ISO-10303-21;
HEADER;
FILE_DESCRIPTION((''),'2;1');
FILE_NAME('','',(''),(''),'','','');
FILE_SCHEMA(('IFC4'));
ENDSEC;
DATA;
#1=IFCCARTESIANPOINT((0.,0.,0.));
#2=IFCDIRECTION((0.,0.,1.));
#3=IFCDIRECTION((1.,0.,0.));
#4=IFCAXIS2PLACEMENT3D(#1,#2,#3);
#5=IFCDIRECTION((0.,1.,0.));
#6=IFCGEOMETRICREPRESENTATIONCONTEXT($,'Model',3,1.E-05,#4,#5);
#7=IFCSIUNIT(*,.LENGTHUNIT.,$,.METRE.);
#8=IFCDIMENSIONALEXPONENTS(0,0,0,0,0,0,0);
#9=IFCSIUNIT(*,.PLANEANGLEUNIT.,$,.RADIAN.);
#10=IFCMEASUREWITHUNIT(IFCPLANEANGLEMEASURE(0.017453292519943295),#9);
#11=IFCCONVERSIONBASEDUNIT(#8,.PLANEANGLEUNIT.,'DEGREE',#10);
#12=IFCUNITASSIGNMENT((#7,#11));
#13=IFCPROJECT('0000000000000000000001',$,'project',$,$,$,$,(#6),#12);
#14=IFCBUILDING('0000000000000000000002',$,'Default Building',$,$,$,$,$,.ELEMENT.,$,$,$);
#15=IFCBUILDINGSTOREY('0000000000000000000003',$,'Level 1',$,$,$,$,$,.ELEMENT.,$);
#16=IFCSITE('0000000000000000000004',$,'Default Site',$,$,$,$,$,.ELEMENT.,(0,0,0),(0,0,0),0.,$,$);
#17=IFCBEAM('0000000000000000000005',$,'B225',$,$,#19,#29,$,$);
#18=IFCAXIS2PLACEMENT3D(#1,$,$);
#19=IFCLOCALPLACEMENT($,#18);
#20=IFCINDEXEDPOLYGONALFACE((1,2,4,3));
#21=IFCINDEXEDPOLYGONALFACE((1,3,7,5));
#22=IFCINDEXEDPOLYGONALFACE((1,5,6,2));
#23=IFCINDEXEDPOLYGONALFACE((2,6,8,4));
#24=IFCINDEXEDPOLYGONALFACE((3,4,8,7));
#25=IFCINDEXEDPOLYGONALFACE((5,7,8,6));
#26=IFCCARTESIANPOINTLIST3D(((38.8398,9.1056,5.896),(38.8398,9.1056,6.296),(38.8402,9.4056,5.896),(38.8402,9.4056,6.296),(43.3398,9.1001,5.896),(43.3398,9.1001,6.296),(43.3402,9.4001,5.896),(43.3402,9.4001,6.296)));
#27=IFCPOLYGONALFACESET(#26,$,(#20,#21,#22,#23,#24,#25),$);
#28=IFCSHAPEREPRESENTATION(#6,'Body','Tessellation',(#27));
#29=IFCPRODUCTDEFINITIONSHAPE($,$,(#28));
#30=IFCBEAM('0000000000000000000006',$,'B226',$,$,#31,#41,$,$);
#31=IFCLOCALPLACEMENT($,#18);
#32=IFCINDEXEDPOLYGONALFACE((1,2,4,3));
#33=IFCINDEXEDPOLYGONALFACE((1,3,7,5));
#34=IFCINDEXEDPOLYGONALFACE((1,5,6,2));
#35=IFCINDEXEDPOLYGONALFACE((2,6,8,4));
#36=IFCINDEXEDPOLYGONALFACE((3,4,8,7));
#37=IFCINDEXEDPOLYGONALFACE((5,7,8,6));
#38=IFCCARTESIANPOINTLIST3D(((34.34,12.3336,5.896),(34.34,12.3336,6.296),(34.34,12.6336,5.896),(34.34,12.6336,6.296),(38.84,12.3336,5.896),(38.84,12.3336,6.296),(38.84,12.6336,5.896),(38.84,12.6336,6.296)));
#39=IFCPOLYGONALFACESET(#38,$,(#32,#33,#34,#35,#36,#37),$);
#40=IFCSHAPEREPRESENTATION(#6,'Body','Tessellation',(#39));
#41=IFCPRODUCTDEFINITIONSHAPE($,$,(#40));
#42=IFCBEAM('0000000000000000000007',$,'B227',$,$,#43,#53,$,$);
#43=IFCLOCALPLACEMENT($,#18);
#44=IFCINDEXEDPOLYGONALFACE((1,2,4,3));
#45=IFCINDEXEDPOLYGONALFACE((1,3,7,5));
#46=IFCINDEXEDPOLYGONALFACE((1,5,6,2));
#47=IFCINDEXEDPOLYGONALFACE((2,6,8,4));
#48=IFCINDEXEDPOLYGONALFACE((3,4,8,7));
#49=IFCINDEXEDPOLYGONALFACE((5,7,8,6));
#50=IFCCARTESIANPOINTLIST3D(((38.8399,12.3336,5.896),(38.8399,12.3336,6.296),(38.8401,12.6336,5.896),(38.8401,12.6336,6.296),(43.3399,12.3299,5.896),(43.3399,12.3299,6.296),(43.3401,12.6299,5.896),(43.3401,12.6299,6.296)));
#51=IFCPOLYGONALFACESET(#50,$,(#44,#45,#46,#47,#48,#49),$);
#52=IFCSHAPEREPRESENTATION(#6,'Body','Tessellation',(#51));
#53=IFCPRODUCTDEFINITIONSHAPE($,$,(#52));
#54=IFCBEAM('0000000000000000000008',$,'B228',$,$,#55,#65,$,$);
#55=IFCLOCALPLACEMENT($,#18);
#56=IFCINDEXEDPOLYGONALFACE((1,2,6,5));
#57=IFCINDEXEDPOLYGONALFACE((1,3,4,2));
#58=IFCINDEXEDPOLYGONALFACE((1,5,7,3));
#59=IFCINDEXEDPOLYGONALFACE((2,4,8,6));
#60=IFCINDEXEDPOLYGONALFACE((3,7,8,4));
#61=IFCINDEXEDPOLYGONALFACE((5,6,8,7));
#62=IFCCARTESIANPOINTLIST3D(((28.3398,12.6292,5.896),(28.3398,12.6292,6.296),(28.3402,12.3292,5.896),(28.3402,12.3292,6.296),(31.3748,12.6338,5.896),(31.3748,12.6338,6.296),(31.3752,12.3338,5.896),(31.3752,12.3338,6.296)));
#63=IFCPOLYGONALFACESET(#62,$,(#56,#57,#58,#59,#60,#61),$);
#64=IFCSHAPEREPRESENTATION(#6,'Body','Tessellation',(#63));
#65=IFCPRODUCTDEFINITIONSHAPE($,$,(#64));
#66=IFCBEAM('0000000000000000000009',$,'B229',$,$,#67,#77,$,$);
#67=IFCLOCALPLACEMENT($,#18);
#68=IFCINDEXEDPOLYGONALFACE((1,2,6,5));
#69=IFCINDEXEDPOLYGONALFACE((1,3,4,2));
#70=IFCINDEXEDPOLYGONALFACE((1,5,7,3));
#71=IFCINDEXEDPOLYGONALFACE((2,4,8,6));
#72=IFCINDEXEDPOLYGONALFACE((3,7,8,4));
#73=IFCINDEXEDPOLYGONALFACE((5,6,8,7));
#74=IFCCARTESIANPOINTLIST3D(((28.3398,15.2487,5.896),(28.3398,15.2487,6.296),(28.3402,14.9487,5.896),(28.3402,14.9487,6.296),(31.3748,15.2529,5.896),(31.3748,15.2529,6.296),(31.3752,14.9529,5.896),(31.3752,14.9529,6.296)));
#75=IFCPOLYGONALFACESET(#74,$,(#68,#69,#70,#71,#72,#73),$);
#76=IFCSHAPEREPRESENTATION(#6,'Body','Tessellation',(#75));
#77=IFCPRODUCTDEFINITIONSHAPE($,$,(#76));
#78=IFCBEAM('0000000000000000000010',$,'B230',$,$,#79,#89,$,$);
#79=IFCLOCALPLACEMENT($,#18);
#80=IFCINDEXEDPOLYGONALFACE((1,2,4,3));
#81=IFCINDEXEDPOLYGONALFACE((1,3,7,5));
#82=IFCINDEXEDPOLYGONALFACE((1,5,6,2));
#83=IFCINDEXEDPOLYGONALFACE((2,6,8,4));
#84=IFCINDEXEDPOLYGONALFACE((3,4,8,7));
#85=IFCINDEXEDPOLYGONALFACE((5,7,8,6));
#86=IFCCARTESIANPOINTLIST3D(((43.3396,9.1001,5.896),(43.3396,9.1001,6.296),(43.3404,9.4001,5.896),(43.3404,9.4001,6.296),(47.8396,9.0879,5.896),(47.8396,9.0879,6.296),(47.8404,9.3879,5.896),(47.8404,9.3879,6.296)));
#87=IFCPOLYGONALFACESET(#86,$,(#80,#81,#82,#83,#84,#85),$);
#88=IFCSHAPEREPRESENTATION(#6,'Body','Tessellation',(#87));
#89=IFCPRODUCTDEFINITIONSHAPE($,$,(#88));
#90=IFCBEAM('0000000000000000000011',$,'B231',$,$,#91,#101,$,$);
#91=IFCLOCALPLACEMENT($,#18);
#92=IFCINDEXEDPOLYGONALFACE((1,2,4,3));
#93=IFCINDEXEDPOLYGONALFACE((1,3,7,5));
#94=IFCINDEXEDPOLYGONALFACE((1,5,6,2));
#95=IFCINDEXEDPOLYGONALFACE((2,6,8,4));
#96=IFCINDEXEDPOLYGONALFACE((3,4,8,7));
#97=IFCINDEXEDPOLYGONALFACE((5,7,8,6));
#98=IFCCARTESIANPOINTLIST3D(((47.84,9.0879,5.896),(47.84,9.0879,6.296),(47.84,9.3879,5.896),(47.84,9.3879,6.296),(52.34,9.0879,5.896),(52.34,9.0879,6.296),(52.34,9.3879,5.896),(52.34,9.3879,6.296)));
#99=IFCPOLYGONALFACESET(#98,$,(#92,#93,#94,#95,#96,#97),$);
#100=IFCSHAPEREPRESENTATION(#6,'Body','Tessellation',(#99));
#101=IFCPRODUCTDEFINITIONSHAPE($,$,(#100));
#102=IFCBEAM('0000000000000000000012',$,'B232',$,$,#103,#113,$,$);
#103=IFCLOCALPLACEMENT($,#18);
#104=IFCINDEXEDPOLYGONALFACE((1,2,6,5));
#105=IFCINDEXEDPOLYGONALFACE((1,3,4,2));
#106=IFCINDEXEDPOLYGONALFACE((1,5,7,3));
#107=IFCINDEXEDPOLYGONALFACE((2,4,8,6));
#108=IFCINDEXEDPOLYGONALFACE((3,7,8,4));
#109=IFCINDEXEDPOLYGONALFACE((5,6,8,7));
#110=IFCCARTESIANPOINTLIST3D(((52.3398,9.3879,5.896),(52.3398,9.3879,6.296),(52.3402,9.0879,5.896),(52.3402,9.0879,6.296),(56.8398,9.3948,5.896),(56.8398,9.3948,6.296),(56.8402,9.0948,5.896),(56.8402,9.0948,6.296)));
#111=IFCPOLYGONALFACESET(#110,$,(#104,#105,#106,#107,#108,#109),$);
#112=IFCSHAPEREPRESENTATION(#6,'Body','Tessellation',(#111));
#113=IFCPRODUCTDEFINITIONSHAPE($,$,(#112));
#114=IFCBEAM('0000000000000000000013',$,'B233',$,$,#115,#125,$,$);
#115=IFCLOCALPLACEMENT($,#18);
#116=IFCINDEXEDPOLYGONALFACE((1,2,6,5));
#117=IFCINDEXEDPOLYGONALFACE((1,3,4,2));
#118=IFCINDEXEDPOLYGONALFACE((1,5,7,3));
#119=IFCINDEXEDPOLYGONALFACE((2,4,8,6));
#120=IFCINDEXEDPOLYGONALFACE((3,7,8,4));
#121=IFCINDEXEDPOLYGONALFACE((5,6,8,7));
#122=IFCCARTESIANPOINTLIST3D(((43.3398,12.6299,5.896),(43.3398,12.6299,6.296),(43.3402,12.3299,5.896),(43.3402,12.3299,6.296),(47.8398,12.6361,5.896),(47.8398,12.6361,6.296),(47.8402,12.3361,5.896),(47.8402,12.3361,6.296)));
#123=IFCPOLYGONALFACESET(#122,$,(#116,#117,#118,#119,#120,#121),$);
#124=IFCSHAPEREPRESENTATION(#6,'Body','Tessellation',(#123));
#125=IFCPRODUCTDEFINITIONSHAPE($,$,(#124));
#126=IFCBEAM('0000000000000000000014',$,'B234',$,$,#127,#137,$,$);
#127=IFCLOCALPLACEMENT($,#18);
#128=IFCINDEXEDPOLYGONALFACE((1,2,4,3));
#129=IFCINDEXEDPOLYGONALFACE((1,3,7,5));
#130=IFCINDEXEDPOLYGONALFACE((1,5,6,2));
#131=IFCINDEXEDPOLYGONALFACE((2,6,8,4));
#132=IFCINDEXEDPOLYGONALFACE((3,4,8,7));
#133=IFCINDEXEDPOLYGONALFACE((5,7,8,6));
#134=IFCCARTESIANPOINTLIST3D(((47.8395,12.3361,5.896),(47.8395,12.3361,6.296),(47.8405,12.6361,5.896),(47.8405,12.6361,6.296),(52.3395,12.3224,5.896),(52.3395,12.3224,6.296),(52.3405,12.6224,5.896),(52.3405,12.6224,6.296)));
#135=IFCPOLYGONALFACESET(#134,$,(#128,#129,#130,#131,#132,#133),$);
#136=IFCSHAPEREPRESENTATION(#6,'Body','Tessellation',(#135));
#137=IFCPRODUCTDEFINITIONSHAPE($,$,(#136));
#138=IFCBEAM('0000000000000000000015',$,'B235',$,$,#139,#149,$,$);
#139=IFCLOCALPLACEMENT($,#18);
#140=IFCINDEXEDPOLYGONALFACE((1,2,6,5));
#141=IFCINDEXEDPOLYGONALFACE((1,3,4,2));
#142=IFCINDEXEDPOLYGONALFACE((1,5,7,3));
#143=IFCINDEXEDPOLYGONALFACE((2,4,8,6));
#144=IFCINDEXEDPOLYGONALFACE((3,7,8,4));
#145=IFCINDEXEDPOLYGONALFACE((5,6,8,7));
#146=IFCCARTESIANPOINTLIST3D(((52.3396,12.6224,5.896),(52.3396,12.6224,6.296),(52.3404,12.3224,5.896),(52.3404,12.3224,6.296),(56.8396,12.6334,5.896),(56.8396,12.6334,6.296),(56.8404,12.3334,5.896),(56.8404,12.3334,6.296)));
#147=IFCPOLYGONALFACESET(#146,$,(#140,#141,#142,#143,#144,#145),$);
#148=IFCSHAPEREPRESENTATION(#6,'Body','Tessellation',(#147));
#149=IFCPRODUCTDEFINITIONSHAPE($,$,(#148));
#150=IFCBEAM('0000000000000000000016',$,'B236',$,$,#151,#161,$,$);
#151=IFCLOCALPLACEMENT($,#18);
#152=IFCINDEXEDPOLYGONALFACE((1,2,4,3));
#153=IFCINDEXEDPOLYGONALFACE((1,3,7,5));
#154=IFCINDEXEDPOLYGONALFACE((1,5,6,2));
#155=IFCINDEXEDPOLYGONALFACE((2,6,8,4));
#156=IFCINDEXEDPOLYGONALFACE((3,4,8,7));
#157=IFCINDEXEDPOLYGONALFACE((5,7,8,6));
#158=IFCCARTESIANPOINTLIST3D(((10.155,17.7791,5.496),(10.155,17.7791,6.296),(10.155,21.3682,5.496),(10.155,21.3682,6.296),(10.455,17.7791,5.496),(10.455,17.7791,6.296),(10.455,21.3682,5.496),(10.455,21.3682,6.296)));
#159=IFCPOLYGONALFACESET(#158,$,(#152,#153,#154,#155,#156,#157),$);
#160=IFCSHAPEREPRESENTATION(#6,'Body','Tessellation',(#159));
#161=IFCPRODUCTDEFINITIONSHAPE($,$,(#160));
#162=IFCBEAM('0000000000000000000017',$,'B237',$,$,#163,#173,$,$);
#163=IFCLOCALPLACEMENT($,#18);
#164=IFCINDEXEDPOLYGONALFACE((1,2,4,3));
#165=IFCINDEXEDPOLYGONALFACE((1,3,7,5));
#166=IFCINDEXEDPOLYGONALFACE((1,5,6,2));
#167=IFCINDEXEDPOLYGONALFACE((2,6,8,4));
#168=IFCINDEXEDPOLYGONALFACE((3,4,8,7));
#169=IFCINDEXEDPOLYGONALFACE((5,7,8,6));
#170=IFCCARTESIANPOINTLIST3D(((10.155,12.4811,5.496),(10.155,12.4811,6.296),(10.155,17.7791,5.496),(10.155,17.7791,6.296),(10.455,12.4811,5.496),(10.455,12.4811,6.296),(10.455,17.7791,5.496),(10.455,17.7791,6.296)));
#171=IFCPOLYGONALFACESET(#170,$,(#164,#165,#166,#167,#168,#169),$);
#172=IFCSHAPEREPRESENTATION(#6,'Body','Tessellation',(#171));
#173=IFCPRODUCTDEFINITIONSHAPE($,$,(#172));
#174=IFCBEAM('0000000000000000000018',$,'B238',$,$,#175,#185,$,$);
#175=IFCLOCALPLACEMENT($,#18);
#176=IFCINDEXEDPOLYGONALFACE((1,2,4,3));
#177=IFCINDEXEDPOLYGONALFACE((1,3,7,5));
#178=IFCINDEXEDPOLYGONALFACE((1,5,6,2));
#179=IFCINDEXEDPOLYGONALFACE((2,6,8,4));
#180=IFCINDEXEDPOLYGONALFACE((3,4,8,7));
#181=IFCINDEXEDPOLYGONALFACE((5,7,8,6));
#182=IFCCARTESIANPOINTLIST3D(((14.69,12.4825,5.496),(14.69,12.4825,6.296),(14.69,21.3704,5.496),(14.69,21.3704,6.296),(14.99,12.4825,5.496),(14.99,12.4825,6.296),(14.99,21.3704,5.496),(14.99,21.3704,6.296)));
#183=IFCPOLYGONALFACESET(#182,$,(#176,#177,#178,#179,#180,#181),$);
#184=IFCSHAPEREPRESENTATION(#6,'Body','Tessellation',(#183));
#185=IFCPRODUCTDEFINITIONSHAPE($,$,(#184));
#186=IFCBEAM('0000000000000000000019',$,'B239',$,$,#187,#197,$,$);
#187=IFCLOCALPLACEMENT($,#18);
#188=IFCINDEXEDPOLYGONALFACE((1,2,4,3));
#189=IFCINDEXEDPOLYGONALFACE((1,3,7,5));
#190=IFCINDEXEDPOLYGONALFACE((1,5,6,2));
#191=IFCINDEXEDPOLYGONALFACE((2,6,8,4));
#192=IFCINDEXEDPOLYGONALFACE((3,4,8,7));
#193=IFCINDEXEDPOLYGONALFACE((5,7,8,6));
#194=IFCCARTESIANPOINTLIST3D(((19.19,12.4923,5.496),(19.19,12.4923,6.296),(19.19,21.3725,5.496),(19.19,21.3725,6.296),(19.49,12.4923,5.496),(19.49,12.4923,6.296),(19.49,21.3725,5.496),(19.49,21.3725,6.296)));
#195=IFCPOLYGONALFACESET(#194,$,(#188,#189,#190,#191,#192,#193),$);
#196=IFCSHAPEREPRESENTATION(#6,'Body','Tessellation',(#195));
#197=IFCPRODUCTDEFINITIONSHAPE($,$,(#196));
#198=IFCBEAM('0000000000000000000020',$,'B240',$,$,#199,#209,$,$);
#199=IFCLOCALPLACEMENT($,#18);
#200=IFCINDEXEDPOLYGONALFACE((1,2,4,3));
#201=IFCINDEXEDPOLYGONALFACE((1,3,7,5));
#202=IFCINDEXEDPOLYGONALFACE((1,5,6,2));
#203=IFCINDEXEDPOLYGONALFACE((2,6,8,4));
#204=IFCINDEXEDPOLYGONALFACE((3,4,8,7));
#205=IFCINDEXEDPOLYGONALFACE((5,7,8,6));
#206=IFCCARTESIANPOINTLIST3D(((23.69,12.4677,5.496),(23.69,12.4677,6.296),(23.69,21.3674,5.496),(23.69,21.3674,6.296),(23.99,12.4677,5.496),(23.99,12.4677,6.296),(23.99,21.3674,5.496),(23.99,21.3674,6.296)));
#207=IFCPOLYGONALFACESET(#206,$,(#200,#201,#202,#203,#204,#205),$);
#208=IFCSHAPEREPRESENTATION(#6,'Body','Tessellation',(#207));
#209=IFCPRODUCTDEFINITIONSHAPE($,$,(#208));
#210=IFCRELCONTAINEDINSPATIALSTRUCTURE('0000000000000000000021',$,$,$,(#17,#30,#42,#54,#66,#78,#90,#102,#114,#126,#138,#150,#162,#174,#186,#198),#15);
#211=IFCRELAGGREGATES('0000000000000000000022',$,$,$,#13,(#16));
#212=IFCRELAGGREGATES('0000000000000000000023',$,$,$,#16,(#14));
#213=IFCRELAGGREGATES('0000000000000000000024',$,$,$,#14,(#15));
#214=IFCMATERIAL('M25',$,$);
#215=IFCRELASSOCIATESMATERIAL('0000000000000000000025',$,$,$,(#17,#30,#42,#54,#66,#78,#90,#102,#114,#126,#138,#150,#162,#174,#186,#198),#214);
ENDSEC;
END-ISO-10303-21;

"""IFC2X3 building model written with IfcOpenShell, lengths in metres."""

from ifc_helpers import new_model, entity, si_unit, converted_unit, direction, frame, frame_2d, origin_with_axes, place, context, project, spatial, rectangle, extrude, material, element, save


model = new_model("IFC2X3")

# Units and contexts
model_context = context("Model", 3, precision=1e-05, world=origin_with_axes(), true_north=direction((0.0, 1.0, 0.0)))
ifc_project = project(units=[si_unit("LENGTHUNIT", "METRE"), converted_unit("PLANEANGLEUNIT", "DEGREE", entity("IfcPlaneAngleMeasure", 0.017453292519943295), si_unit("PLANEANGLEUNIT", "RADIAN"), dimensions=[0, 0, 0, 0, 0, 0, 0])], contexts=[model_context])

# Site, building, storey
site = spatial("IfcSite", under=ifc_project, Name="Default Site", CompositionType="ELEMENT", RefLatitude=(0, 0, 0), RefLongitude=(0, 0, 0), RefElevation=0.0)
building = spatial("IfcBuilding", under=site, Name="Default Building", CompositionType="ELEMENT")
storey = spatial("IfcBuildingStorey", under=building, Name="Level 1", CompositionType="ELEMENT")

# Beams
ifc_material = material(Name="M25")
placement = place(None, origin_with_axes())
element("IfcBeam", 1, at=placement, inside=storey, material=ifc_material, Name="B225", context=model_context, shape_type="SweptSolid", body=[
    extrude(rectangle(XDim=0.3, YDim=0.4, at=frame_2d((0.0, 0.0), x_axis=(0.0, 1.0, 0.0))), frame((38.84, 9.2556, 6.096), z_axis=(0.999999, -0.001227, 0.0), x_axis=(0.0, 0.0, -1.0)), (0.0, 0.0, 1.0), 4.5),
])
element("IfcBeam", 2, at=placement, inside=storey, material=ifc_material, Name="B226", context=model_context, shape_type="SweptSolid", body=[
    extrude(rectangle(XDim=0.3, YDim=0.4, at=frame_2d((0.0, 0.0), x_axis=(0.0, 1.0, 0.0))), frame((34.34, 12.4836, 6.096), z_axis=(1.0, -0.000008, 0.0), x_axis=(0.0, 0.0, -1.0)), (0.0, 0.0, 1.0), 4.5),
])
element("IfcBeam", 3, at=placement, inside=storey, material=ifc_material, Name="B227", context=model_context, shape_type="SweptSolid", body=[
    extrude(rectangle(XDim=0.3, YDim=0.4, at=frame_2d((0.0, 0.0), x_axis=(0.0, 1.0, 0.0))), frame((38.84, 12.4836, 6.096), z_axis=(1.0, -0.000826, 0.0), x_axis=(0.0, 0.0, -1.0)), (0.0, 0.0, 1.0), 4.5),
])
element("IfcBeam", 4, at=placement, inside=storey, material=ifc_material, Name="B228", context=model_context, shape_type="SweptSolid", body=[
    extrude(rectangle(XDim=0.3, YDim=0.4, at=frame_2d((0.0, 0.0), x_axis=(0.0, 1.0, 0.0))), frame((28.34, 12.4792, 6.096), z_axis=(0.999999, 0.001542, 0.0), x_axis=(0.0, 0.0, -1.0)), (0.0, 0.0, 1.0), 3.035),
])
element("IfcBeam", 5, at=placement, inside=storey, material=ifc_material, Name="B229", context=model_context, shape_type="SweptSolid", body=[
    extrude(rectangle(XDim=0.3, YDim=0.4, at=frame_2d((0.0, 0.0), x_axis=(0.0, 1.0, 0.0))), frame((31.375, 15.1029, 6.096), z_axis=(-0.999999, -0.001391, 0.0), x_axis=(0.0, 0.0, -1.0)), (0.0, 0.0, 1.0), 3.035),
])
element("IfcBeam", 6, at=placement, inside=storey, material=ifc_material, Name="B230", context=model_context, shape_type="SweptSolid", body=[
    extrude(rectangle(XDim=0.3, YDim=0.4, at=frame_2d((0.0, 0.0), x_axis=(0.0, 1.0, 0.0))), frame((43.34, 9.2501, 6.096), z_axis=(0.999996, -0.002702, 0.0), x_axis=(0.0, 0.0, -1.0)), (0.0, 0.0, 1.0), 4.5),
])
element("IfcBeam", 7, at=placement, inside=storey, material=ifc_material, Name="B231", context=model_context, shape_type="SweptSolid", body=[
    extrude(rectangle(XDim=0.3, YDim=0.4, at=frame_2d((0.0, 0.0), x_axis=(0.0, 1.0, 0.0))), frame((47.84, 9.2379, 6.096), z_axis=(1.0, 0.0, 0.0), x_axis=(0.0, 0.0, -1.0)), (0.0, 0.0, 1.0), 4.5),
])
element("IfcBeam", 8, at=placement, inside=storey, material=ifc_material, Name="B232", context=model_context, shape_type="SweptSolid", body=[
    extrude(rectangle(XDim=0.3, YDim=0.4, at=frame_2d((0.0, 0.0), x_axis=(0.0, 1.0, 0.0))), frame((52.34, 9.2379, 6.096), z_axis=(0.999999, 0.001537, 0.0), x_axis=(0.0, 0.0, -1.0)), (0.0, 0.0, 1.0), 4.5),
])
element("IfcBeam", 9, at=placement, inside=storey, material=ifc_material, Name="B233", context=model_context, shape_type="SweptSolid", body=[
    extrude(rectangle(XDim=0.3, YDim=0.4, at=frame_2d((0.0, 0.0), x_axis=(0.0, 1.0, 0.0))), frame((43.34, 12.4799, 6.096), z_axis=(0.999999, 0.001374, 0.0), x_axis=(0.0, 0.0, -1.0)), (0.0, 0.0, 1.0), 4.5),
])
element("IfcBeam", 10, at=placement, inside=storey, material=ifc_material, Name="B234", context=model_context, shape_type="SweptSolid", body=[
    extrude(rectangle(XDim=0.3, YDim=0.4, at=frame_2d((0.0, 0.0), x_axis=(0.0, 1.0, 0.0))), frame((47.84, 12.4861, 6.096), z_axis=(0.999995, -0.003045, 0.0), x_axis=(0.0, 0.0, -1.0)), (0.0, 0.0, 1.0), 4.5),
])
element("IfcBeam", 11, at=placement, inside=storey, material=ifc_material, Name="B235", context=model_context, shape_type="SweptSolid", body=[
    extrude(rectangle(XDim=0.3, YDim=0.4, at=frame_2d((0.0, 0.0), x_axis=(0.0, 1.0, 0.0))), frame((52.34, 12.4724, 6.096), z_axis=(0.999997, 0.002456, 0.0), x_axis=(0.0, 0.0, -1.0)), (0.0, 0.0, 1.0), 4.5),
])
element("IfcBeam", 12, at=placement, inside=storey, material=ifc_material, Name="B236", context=model_context, shape_type="SweptSolid", body=[
    extrude(rectangle(XDim=0.3, YDim=0.8, at=frame_2d((0.0, 0.0), x_axis=(0.0, 1.0, 0.0))), frame((10.305, 21.3682, 5.896), z_axis=(0.0, -1.0, 0.0), x_axis=(0.0, 0.0, -1.0)), (0.0, 0.0, 1.0), 3.5891),
])
element("IfcBeam", 13, at=placement, inside=storey, material=ifc_material, Name="B237", context=model_context, shape_type="SweptSolid", body=[
    extrude(rectangle(XDim=0.3, YDim=0.8, at=frame_2d((0.0, 0.0), x_axis=(0.0, 1.0, 0.0))), frame((10.305, 17.7791, 5.896), z_axis=(0.0, -1.0, 0.0), x_axis=(0.0, 0.0, -1.0)), (0.0, 0.0, 1.0), 5.298),
])
element("IfcBeam", 14, at=placement, inside=storey, material=ifc_material, Name="B238", context=model_context, shape_type="SweptSolid", body=[
    extrude(rectangle(XDim=0.3, YDim=0.8, at=frame_2d((0.0, 0.0), x_axis=(0.0, 1.0, 0.0))), frame((14.84, 21.3704, 5.896), z_axis=(0.0, -1.0, 0.0), x_axis=(0.0, 0.0, -1.0)), (0.0, 0.0, 1.0), 8.8879),
])
element("IfcBeam", 15, at=placement, inside=storey, material=ifc_material, Name="B239", context=model_context, shape_type="SweptSolid", body=[
    extrude(rectangle(XDim=0.3, YDim=0.8, at=frame_2d((0.0, 0.0), x_axis=(0.0, 1.0, 0.0))), frame((19.34, 21.3725, 5.896), z_axis=(0.0, -1.0, 0.0), x_axis=(0.0, 0.0, -1.0)), (0.0, 0.0, 1.0), 8.8802),
])
element("IfcBeam", 16, at=placement, inside=storey, material=ifc_material, Name="B240", context=model_context, shape_type="SweptSolid", body=[
    extrude(rectangle(XDim=0.3, YDim=0.8, at=frame_2d((0.0, 0.0), x_axis=(0.0, 1.0, 0.0))), frame((23.84, 21.3674, 5.896), z_axis=(0.0, -1.0, 0.0), x_axis=(0.0, 0.0, -1.0)), (0.0, 0.0, 1.0), 8.8997),
])

save(model, "model.ifc")
